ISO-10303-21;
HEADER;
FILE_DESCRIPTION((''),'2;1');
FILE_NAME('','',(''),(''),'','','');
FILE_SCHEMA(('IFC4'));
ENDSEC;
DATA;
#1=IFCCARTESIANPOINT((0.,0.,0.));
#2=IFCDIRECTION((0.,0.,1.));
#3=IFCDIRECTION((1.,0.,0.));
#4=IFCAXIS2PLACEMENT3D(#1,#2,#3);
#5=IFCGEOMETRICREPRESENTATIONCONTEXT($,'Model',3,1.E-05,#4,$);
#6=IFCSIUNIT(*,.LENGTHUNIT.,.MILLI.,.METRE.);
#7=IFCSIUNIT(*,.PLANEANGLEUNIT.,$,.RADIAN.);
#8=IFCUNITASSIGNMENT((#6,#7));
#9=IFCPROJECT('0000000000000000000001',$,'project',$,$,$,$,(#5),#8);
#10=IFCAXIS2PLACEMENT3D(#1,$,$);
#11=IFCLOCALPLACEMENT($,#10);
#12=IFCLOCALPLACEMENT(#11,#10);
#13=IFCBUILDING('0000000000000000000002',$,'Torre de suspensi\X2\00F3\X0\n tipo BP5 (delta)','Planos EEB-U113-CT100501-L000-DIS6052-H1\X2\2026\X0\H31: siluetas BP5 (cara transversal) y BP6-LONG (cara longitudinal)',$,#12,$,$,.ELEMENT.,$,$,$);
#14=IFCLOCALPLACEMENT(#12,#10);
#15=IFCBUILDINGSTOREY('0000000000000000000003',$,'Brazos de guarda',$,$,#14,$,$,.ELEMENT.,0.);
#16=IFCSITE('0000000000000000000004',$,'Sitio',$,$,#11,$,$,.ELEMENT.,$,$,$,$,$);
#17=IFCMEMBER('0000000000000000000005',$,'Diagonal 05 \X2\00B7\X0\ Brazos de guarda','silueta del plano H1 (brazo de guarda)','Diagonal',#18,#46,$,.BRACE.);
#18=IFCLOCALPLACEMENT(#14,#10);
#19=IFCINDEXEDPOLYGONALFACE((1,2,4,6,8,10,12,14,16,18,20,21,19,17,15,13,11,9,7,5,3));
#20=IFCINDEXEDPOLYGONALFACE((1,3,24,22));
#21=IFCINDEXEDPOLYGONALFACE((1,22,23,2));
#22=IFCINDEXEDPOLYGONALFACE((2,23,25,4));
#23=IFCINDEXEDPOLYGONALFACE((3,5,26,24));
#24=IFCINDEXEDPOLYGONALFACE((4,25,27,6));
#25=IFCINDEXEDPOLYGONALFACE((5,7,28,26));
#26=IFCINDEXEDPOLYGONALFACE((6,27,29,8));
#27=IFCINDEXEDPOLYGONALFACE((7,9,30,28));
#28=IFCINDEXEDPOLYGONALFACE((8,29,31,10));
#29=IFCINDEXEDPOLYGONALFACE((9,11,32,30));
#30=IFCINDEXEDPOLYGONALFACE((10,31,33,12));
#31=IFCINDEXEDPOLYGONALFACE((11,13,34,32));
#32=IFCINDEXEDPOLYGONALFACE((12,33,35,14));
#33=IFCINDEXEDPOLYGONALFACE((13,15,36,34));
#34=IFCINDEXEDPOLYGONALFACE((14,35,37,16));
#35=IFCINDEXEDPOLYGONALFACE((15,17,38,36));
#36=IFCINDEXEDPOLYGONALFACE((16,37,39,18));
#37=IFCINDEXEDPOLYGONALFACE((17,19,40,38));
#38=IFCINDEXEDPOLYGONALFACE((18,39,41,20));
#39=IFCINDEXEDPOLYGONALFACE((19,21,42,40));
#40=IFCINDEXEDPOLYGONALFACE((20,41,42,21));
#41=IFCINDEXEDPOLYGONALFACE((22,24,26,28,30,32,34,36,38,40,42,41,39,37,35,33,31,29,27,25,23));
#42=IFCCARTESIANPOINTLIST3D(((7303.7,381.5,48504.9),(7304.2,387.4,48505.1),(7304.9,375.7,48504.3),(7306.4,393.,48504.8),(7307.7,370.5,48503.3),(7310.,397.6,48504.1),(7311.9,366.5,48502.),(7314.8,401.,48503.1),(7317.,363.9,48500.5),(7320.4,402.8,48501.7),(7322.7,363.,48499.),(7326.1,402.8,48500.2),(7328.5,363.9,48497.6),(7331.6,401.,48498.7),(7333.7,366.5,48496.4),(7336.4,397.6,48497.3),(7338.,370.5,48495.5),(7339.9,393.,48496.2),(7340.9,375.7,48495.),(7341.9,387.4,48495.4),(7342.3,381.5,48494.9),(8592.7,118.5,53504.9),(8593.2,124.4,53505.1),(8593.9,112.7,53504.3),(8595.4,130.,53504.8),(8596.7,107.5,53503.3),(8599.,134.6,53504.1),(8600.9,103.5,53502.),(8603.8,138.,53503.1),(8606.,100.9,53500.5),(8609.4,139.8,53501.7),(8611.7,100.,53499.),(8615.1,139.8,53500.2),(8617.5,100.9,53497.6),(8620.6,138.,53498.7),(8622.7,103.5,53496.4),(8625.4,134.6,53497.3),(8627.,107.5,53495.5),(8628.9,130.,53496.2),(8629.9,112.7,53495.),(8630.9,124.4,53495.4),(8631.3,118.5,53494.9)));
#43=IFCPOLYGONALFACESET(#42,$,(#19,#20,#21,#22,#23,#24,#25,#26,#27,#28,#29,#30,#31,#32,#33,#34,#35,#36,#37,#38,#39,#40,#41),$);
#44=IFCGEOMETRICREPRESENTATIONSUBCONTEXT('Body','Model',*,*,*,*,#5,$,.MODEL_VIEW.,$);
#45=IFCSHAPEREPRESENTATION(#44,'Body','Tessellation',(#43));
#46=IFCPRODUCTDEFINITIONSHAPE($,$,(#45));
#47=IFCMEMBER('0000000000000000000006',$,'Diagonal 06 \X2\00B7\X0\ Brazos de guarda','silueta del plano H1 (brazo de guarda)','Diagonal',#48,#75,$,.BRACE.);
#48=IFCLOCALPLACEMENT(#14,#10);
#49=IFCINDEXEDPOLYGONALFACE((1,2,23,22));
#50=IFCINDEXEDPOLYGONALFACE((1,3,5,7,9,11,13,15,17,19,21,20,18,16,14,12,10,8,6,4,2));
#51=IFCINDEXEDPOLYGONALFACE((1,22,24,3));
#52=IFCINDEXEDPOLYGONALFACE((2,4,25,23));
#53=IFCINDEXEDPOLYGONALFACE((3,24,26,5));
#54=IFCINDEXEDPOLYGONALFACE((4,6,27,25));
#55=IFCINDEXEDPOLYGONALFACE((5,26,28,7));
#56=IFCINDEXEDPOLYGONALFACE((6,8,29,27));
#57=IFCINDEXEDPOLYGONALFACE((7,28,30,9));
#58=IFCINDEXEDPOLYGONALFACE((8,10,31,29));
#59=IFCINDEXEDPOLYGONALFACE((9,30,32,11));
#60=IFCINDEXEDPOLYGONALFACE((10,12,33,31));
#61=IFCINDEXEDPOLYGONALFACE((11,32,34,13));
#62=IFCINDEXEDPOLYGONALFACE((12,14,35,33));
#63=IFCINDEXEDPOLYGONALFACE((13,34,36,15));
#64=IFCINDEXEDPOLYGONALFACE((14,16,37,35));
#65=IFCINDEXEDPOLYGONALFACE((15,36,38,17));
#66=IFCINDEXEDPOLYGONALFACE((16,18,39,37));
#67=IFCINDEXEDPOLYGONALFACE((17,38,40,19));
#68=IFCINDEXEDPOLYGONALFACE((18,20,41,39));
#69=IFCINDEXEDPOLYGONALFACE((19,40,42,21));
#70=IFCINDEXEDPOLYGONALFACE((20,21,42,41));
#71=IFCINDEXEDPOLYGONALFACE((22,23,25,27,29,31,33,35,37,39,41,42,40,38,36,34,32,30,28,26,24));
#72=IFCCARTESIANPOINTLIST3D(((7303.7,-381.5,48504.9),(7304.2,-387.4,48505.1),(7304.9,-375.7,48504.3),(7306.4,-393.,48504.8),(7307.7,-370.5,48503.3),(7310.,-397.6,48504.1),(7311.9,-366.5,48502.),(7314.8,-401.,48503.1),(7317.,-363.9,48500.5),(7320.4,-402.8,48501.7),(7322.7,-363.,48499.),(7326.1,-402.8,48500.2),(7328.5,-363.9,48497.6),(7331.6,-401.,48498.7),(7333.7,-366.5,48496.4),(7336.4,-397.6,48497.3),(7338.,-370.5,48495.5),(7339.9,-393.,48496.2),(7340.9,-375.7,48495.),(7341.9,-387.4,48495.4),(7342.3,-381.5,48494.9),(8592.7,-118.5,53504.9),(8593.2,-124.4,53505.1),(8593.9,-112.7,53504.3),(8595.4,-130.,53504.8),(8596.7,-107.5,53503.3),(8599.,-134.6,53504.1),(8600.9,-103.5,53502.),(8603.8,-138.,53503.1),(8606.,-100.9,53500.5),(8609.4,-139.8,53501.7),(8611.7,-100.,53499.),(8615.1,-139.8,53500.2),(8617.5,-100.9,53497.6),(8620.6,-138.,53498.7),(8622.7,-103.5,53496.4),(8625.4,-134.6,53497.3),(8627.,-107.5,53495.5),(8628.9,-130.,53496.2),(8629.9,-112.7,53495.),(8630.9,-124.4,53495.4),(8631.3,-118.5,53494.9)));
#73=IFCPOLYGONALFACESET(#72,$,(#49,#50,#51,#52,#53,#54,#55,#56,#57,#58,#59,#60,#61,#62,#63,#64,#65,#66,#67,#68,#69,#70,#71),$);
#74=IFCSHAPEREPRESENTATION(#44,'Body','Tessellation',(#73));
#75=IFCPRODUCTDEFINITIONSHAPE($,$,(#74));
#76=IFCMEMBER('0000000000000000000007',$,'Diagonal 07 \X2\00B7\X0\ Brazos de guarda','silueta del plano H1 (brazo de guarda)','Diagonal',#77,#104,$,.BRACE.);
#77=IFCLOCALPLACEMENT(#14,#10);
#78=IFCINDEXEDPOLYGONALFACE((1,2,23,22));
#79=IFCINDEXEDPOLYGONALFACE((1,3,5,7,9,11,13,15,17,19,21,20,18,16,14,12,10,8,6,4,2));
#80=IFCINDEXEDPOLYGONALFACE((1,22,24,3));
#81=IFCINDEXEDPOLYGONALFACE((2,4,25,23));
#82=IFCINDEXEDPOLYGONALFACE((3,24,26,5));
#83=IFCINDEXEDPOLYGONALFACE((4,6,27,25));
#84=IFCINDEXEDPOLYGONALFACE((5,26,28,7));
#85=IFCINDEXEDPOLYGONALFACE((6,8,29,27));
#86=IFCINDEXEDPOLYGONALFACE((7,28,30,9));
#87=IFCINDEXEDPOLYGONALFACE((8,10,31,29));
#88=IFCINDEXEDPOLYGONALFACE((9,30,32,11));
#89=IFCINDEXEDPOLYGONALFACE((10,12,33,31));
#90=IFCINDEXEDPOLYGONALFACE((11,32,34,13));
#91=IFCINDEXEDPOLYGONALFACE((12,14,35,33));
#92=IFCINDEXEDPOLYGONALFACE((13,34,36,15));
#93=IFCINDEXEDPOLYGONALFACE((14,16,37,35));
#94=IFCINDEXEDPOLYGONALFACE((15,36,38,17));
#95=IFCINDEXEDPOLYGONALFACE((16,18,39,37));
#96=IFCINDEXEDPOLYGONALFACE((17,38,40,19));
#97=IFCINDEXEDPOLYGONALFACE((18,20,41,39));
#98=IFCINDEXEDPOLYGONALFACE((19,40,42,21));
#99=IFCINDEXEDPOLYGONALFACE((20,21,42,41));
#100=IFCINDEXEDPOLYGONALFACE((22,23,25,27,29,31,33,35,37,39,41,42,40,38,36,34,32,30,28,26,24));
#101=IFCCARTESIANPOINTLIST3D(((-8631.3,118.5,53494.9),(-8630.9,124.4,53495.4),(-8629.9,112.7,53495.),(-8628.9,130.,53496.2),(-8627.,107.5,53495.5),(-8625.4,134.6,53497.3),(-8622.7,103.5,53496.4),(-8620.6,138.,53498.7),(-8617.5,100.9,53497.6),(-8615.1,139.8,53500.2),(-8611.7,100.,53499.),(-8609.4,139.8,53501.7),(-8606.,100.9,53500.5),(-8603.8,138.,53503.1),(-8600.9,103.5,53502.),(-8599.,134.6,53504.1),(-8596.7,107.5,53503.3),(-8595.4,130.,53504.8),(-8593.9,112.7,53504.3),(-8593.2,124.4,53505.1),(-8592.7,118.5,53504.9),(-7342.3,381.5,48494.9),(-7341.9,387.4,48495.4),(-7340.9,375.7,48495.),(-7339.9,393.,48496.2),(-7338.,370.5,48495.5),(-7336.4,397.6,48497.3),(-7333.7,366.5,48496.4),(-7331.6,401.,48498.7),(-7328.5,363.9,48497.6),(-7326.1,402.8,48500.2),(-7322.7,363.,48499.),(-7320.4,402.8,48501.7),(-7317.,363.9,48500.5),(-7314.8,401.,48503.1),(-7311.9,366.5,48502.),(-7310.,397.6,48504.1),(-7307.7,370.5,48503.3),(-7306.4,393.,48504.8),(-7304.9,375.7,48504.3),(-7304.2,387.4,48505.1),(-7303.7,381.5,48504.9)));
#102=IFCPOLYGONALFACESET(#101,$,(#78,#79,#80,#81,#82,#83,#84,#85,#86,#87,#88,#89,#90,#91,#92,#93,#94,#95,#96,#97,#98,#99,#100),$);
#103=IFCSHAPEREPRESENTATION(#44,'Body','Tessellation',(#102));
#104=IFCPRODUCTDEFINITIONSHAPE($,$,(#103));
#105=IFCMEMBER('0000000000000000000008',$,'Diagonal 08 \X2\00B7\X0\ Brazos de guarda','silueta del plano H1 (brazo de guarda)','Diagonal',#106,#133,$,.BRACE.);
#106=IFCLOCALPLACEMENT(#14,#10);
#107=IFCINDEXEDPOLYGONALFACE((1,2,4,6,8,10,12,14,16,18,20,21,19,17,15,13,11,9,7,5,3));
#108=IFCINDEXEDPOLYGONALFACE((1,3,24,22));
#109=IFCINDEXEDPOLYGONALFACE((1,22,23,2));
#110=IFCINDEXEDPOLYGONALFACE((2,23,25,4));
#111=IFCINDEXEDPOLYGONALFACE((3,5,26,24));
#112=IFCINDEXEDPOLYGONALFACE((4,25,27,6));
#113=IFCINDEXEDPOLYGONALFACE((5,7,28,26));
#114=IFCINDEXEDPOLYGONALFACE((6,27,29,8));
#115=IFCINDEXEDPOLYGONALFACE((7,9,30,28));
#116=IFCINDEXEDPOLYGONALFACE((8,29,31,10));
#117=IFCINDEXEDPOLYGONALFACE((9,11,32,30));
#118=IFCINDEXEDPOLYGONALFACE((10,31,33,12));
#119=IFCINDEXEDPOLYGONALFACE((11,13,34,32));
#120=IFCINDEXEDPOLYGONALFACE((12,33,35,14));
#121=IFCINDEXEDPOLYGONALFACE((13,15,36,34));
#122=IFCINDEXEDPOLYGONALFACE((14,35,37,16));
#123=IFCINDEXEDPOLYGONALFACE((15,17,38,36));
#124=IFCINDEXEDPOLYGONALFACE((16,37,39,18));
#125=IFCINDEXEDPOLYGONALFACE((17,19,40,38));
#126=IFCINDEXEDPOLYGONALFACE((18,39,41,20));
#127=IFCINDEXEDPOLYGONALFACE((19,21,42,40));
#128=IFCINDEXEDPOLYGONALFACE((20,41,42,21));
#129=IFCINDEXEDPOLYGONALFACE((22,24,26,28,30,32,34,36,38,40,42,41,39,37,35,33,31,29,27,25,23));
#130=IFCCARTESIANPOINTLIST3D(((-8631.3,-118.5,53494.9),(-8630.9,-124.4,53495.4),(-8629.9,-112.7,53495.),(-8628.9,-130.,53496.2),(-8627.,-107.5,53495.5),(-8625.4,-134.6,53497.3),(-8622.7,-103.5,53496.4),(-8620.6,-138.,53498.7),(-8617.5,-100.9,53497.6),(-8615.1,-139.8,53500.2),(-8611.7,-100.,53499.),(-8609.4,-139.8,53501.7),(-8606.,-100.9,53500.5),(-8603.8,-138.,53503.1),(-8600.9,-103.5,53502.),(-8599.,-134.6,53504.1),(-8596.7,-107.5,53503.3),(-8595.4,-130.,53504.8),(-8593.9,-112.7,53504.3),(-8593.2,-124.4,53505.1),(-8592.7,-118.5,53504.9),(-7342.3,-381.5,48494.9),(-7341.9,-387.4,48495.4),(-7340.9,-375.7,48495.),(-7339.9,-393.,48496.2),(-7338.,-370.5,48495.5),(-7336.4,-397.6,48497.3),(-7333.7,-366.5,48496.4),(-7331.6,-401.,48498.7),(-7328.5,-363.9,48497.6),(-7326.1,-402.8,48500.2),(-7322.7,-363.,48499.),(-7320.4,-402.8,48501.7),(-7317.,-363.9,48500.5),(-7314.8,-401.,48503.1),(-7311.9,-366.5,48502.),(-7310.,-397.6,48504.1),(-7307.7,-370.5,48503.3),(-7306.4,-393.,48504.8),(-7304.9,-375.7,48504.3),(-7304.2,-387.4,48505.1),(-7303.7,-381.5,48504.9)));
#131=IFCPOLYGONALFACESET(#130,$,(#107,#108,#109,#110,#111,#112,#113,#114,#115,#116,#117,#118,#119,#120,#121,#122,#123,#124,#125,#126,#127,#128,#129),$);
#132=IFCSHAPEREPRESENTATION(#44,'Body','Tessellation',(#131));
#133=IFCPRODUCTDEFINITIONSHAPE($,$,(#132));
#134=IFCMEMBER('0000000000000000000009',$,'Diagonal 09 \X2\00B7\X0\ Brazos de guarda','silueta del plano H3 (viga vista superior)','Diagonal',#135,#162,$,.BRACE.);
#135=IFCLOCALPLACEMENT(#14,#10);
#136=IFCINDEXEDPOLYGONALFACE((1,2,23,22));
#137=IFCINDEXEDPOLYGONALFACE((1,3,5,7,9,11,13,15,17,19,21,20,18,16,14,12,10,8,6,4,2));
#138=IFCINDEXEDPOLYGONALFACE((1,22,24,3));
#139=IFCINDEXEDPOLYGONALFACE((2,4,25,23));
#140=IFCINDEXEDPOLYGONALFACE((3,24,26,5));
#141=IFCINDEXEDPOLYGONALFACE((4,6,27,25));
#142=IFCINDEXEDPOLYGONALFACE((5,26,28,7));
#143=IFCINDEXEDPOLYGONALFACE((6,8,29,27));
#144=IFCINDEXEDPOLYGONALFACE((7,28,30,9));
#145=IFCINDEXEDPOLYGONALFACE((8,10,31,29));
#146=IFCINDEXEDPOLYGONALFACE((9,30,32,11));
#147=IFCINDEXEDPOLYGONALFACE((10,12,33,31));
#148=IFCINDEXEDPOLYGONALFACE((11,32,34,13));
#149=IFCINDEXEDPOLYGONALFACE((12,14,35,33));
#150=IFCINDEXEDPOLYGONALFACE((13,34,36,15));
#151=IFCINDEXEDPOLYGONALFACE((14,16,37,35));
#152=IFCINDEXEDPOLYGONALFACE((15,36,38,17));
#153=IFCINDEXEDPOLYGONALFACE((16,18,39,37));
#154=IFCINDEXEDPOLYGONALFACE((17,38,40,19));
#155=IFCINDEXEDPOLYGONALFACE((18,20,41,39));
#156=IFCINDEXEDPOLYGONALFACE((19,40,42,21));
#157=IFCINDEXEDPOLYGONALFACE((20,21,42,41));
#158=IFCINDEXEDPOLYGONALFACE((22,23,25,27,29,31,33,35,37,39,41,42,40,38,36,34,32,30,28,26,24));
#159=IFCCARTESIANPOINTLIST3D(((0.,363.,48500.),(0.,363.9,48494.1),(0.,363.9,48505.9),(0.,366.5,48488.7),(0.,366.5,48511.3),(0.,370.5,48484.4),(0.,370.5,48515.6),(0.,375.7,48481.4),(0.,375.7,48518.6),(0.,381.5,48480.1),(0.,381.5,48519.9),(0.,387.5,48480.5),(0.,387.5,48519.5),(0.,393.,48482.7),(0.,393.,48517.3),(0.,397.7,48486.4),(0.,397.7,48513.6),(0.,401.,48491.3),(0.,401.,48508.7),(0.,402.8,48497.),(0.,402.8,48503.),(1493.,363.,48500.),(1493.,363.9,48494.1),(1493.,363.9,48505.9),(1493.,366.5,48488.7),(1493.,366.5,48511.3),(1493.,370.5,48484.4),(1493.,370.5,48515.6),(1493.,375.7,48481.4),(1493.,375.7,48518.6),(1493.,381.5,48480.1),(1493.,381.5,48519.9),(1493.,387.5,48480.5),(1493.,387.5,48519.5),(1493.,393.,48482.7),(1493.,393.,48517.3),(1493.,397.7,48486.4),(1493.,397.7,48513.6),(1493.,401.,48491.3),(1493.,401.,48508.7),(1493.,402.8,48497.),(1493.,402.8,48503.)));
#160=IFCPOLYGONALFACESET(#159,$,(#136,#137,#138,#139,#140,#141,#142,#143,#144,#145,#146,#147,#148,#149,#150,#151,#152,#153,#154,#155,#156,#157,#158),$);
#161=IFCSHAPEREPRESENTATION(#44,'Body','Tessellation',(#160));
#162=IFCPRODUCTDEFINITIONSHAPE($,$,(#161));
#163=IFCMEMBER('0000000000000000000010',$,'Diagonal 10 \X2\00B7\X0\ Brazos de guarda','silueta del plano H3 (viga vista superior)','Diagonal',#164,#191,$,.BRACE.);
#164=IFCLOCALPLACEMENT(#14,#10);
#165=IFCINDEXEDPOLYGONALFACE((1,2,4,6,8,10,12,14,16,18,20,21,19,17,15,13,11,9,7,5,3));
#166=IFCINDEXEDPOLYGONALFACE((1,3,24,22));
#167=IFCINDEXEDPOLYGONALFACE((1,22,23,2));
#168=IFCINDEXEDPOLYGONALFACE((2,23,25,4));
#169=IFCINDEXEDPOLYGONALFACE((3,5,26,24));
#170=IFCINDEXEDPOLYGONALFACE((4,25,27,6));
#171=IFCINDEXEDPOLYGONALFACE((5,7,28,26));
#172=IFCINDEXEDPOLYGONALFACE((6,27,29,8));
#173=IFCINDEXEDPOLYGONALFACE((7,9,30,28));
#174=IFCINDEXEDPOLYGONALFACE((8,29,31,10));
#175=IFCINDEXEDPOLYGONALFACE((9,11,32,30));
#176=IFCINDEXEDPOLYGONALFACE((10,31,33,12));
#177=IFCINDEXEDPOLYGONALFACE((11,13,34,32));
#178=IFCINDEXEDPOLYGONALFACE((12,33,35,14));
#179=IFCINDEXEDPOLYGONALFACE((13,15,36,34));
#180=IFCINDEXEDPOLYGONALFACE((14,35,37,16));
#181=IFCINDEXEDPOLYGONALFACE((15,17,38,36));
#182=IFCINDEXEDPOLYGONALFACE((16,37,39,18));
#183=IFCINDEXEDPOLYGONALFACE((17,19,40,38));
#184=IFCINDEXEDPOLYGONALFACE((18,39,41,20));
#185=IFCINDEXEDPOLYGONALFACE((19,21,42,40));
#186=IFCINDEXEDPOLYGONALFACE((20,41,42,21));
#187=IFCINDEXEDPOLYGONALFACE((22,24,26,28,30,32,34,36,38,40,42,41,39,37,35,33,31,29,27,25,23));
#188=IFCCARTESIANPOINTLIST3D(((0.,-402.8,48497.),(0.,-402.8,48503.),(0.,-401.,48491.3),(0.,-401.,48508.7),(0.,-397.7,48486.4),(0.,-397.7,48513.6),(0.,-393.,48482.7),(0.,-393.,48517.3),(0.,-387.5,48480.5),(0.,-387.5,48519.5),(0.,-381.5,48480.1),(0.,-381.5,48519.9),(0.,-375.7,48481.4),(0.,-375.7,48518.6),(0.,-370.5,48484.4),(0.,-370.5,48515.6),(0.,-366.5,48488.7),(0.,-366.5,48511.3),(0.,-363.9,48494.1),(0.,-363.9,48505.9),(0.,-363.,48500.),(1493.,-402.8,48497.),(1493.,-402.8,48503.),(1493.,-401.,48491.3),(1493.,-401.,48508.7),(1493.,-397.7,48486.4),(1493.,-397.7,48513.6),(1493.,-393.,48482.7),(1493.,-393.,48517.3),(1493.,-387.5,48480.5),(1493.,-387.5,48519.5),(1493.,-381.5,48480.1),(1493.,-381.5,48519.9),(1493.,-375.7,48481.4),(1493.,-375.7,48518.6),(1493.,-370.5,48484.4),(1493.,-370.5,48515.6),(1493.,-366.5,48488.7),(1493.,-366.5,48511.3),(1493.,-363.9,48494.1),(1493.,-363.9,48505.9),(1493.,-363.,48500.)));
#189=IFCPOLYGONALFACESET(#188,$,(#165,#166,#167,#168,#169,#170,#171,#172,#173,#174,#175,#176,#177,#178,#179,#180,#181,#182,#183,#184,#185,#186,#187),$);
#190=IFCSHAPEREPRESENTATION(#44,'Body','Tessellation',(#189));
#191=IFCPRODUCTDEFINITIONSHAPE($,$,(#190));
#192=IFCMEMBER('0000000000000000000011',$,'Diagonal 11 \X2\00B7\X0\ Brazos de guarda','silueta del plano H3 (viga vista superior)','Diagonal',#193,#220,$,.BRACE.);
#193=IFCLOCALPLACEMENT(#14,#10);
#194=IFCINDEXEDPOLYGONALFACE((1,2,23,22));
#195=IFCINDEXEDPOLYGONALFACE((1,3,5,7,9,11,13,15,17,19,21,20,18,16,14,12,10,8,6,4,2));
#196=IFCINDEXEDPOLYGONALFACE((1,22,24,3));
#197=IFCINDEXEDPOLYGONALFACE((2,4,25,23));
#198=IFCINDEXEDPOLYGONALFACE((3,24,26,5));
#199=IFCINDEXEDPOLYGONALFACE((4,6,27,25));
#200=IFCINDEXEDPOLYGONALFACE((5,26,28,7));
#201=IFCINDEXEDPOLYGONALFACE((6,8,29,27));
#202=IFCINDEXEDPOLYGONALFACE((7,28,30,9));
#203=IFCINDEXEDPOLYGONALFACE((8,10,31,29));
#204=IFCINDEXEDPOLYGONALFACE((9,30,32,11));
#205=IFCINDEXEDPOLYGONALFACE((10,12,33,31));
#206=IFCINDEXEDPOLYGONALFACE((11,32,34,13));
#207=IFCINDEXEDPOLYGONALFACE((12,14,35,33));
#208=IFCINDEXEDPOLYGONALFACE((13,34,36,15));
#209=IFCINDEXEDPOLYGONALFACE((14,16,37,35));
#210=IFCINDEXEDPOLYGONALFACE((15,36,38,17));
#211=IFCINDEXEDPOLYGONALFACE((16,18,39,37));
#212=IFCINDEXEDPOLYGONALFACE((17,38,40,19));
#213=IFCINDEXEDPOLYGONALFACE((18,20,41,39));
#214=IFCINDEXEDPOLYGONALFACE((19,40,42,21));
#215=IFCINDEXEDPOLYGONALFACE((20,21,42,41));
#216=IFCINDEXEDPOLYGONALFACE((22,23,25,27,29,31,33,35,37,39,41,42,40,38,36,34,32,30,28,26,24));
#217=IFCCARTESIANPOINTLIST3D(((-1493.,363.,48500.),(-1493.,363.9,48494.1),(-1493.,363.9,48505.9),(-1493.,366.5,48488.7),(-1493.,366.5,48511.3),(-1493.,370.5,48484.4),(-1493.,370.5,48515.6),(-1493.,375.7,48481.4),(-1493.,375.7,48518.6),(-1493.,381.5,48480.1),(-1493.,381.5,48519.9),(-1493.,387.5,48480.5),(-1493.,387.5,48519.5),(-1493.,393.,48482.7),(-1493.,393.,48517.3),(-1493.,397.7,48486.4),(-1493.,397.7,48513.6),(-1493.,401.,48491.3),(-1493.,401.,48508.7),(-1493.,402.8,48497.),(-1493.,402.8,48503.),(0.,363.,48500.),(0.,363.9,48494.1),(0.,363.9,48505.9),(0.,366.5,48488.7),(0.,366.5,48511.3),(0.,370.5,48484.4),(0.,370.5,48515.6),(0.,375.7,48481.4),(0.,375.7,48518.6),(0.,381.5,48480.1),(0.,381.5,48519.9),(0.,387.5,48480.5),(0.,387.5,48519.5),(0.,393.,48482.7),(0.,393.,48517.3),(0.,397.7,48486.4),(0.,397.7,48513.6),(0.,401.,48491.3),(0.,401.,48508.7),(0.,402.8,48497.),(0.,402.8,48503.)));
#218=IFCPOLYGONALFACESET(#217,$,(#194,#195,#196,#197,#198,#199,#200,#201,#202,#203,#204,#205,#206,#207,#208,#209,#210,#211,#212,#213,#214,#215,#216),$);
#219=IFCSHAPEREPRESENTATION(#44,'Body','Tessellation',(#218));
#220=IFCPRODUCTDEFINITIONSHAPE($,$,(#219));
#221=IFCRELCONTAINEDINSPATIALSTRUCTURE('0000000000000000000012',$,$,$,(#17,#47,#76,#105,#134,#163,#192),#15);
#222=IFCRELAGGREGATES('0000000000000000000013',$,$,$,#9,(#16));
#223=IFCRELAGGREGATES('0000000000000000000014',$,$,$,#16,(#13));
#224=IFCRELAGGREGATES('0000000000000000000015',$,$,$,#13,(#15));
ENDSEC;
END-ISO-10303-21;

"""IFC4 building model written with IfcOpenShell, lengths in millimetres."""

from ifc_helpers import new_model, si_unit, frame, origin, origin_with_axes, place, context, subcontext, project, spatial, circle, extrude, element, save


model = new_model("IFC4")

# Units and contexts
model_context = context("Model", 3, precision=1e-05, world=origin_with_axes())
body_context = subcontext(model_context, "Body", "Model", "MODEL_VIEW")
ifc_project = project(units=[si_unit("LENGTHUNIT", "METRE", prefix="MILLI"), si_unit("PLANEANGLEUNIT", "RADIAN")], contexts=[model_context])

# Site, building, storey
site_placement = place(None, origin())
site = spatial("IfcSite", under=ifc_project, at=site_placement, Name="Sitio", CompositionType="ELEMENT")
building_placement = place(site_placement, origin())
building = spatial("IfcBuilding", under=site, at=building_placement, Name="Torre de suspensión tipo BP5 (delta)", Description="Planos EEB-U113-CT100501-L000-DIS6052-H1…H31: siluetas BP5 (cara transversal) y BP6-LONG (cara longitudinal)", CompositionType="ELEMENT")
storey_placement = place(building_placement, origin())
storey = spatial("IfcBuildingStorey", under=building, at=storey_placement, Name="Brazos de guarda", CompositionType="ELEMENT", Elevation=0.0)

# Members
for number, where, z_axis, x_axis, name in (
    (1, (7323.0, 383.0, 48500.0), (0.249315, -0.050869, 0.967086), (-0.012699, -0.998705, -0.049258), "Diagonal 05 · Brazos de guarda"),
    (2, (7323.0, -383.0, 48500.0), (0.249315, 0.050869, 0.967086), (-0.012699, 0.998705, -0.049258), "Diagonal 06 · Brazos de guarda"),
    (3, (-7323.0, 383.0, 48500.0), (-0.249315, -0.050869, 0.967086), (0.012699, -0.998705, -0.049258), "Diagonal 07 · Brazos de guarda"),
    (4, (-7323.0, -383.0, 48500.0), (-0.249315, 0.050869, 0.967086), (0.012699, 0.998705, -0.049258), "Diagonal 08 · Brazos de guarda"),
):
    element("IfcMember", number, at=place(storey_placement, frame(where, z_axis=z_axis, x_axis=x_axis)), inside=storey, Name=name, Description="silueta del plano H1 (brazo de guarda)", ObjectType="Diagonal", PredefinedType="BRACE", context=body_context, shape_type="SweptSolid", body=[
        extrude(circle(Radius=20.0), None, (0.0, 0.0, 1.0), 5170.2),
    ])
for number, where, z_axis, x_axis, name in (
    (5, (0.0, 383.0, 48500.0), (1.0, 0.0, 0.0), (0.0, -1.0, 0.0), "Diagonal 09 · Brazos de guarda"),
    (6, (0.0, -383.0, 48500.0), (1.0, 0.0, 0.0), (0.0, 1.0, 0.0), "Diagonal 10 · Brazos de guarda"),
    (7, (0.0, 383.0, 48500.0), (-1.0, 0.0, 0.0), (0.0, -1.0, 0.0), "Diagonal 11 · Brazos de guarda"),
):
    element("IfcMember", number, at=place(storey_placement, frame(where, z_axis=z_axis, x_axis=x_axis)), inside=storey, Name=name, Description="silueta del plano H3 (viga vista superior)", ObjectType="Diagonal", PredefinedType="BRACE", context=body_context, shape_type="SweptSolid", body=[
        extrude(circle(Radius=20.0), None, (0.0, 0.0, 1.0), 1493.0),
    ])

save(model, "model.ifc")
